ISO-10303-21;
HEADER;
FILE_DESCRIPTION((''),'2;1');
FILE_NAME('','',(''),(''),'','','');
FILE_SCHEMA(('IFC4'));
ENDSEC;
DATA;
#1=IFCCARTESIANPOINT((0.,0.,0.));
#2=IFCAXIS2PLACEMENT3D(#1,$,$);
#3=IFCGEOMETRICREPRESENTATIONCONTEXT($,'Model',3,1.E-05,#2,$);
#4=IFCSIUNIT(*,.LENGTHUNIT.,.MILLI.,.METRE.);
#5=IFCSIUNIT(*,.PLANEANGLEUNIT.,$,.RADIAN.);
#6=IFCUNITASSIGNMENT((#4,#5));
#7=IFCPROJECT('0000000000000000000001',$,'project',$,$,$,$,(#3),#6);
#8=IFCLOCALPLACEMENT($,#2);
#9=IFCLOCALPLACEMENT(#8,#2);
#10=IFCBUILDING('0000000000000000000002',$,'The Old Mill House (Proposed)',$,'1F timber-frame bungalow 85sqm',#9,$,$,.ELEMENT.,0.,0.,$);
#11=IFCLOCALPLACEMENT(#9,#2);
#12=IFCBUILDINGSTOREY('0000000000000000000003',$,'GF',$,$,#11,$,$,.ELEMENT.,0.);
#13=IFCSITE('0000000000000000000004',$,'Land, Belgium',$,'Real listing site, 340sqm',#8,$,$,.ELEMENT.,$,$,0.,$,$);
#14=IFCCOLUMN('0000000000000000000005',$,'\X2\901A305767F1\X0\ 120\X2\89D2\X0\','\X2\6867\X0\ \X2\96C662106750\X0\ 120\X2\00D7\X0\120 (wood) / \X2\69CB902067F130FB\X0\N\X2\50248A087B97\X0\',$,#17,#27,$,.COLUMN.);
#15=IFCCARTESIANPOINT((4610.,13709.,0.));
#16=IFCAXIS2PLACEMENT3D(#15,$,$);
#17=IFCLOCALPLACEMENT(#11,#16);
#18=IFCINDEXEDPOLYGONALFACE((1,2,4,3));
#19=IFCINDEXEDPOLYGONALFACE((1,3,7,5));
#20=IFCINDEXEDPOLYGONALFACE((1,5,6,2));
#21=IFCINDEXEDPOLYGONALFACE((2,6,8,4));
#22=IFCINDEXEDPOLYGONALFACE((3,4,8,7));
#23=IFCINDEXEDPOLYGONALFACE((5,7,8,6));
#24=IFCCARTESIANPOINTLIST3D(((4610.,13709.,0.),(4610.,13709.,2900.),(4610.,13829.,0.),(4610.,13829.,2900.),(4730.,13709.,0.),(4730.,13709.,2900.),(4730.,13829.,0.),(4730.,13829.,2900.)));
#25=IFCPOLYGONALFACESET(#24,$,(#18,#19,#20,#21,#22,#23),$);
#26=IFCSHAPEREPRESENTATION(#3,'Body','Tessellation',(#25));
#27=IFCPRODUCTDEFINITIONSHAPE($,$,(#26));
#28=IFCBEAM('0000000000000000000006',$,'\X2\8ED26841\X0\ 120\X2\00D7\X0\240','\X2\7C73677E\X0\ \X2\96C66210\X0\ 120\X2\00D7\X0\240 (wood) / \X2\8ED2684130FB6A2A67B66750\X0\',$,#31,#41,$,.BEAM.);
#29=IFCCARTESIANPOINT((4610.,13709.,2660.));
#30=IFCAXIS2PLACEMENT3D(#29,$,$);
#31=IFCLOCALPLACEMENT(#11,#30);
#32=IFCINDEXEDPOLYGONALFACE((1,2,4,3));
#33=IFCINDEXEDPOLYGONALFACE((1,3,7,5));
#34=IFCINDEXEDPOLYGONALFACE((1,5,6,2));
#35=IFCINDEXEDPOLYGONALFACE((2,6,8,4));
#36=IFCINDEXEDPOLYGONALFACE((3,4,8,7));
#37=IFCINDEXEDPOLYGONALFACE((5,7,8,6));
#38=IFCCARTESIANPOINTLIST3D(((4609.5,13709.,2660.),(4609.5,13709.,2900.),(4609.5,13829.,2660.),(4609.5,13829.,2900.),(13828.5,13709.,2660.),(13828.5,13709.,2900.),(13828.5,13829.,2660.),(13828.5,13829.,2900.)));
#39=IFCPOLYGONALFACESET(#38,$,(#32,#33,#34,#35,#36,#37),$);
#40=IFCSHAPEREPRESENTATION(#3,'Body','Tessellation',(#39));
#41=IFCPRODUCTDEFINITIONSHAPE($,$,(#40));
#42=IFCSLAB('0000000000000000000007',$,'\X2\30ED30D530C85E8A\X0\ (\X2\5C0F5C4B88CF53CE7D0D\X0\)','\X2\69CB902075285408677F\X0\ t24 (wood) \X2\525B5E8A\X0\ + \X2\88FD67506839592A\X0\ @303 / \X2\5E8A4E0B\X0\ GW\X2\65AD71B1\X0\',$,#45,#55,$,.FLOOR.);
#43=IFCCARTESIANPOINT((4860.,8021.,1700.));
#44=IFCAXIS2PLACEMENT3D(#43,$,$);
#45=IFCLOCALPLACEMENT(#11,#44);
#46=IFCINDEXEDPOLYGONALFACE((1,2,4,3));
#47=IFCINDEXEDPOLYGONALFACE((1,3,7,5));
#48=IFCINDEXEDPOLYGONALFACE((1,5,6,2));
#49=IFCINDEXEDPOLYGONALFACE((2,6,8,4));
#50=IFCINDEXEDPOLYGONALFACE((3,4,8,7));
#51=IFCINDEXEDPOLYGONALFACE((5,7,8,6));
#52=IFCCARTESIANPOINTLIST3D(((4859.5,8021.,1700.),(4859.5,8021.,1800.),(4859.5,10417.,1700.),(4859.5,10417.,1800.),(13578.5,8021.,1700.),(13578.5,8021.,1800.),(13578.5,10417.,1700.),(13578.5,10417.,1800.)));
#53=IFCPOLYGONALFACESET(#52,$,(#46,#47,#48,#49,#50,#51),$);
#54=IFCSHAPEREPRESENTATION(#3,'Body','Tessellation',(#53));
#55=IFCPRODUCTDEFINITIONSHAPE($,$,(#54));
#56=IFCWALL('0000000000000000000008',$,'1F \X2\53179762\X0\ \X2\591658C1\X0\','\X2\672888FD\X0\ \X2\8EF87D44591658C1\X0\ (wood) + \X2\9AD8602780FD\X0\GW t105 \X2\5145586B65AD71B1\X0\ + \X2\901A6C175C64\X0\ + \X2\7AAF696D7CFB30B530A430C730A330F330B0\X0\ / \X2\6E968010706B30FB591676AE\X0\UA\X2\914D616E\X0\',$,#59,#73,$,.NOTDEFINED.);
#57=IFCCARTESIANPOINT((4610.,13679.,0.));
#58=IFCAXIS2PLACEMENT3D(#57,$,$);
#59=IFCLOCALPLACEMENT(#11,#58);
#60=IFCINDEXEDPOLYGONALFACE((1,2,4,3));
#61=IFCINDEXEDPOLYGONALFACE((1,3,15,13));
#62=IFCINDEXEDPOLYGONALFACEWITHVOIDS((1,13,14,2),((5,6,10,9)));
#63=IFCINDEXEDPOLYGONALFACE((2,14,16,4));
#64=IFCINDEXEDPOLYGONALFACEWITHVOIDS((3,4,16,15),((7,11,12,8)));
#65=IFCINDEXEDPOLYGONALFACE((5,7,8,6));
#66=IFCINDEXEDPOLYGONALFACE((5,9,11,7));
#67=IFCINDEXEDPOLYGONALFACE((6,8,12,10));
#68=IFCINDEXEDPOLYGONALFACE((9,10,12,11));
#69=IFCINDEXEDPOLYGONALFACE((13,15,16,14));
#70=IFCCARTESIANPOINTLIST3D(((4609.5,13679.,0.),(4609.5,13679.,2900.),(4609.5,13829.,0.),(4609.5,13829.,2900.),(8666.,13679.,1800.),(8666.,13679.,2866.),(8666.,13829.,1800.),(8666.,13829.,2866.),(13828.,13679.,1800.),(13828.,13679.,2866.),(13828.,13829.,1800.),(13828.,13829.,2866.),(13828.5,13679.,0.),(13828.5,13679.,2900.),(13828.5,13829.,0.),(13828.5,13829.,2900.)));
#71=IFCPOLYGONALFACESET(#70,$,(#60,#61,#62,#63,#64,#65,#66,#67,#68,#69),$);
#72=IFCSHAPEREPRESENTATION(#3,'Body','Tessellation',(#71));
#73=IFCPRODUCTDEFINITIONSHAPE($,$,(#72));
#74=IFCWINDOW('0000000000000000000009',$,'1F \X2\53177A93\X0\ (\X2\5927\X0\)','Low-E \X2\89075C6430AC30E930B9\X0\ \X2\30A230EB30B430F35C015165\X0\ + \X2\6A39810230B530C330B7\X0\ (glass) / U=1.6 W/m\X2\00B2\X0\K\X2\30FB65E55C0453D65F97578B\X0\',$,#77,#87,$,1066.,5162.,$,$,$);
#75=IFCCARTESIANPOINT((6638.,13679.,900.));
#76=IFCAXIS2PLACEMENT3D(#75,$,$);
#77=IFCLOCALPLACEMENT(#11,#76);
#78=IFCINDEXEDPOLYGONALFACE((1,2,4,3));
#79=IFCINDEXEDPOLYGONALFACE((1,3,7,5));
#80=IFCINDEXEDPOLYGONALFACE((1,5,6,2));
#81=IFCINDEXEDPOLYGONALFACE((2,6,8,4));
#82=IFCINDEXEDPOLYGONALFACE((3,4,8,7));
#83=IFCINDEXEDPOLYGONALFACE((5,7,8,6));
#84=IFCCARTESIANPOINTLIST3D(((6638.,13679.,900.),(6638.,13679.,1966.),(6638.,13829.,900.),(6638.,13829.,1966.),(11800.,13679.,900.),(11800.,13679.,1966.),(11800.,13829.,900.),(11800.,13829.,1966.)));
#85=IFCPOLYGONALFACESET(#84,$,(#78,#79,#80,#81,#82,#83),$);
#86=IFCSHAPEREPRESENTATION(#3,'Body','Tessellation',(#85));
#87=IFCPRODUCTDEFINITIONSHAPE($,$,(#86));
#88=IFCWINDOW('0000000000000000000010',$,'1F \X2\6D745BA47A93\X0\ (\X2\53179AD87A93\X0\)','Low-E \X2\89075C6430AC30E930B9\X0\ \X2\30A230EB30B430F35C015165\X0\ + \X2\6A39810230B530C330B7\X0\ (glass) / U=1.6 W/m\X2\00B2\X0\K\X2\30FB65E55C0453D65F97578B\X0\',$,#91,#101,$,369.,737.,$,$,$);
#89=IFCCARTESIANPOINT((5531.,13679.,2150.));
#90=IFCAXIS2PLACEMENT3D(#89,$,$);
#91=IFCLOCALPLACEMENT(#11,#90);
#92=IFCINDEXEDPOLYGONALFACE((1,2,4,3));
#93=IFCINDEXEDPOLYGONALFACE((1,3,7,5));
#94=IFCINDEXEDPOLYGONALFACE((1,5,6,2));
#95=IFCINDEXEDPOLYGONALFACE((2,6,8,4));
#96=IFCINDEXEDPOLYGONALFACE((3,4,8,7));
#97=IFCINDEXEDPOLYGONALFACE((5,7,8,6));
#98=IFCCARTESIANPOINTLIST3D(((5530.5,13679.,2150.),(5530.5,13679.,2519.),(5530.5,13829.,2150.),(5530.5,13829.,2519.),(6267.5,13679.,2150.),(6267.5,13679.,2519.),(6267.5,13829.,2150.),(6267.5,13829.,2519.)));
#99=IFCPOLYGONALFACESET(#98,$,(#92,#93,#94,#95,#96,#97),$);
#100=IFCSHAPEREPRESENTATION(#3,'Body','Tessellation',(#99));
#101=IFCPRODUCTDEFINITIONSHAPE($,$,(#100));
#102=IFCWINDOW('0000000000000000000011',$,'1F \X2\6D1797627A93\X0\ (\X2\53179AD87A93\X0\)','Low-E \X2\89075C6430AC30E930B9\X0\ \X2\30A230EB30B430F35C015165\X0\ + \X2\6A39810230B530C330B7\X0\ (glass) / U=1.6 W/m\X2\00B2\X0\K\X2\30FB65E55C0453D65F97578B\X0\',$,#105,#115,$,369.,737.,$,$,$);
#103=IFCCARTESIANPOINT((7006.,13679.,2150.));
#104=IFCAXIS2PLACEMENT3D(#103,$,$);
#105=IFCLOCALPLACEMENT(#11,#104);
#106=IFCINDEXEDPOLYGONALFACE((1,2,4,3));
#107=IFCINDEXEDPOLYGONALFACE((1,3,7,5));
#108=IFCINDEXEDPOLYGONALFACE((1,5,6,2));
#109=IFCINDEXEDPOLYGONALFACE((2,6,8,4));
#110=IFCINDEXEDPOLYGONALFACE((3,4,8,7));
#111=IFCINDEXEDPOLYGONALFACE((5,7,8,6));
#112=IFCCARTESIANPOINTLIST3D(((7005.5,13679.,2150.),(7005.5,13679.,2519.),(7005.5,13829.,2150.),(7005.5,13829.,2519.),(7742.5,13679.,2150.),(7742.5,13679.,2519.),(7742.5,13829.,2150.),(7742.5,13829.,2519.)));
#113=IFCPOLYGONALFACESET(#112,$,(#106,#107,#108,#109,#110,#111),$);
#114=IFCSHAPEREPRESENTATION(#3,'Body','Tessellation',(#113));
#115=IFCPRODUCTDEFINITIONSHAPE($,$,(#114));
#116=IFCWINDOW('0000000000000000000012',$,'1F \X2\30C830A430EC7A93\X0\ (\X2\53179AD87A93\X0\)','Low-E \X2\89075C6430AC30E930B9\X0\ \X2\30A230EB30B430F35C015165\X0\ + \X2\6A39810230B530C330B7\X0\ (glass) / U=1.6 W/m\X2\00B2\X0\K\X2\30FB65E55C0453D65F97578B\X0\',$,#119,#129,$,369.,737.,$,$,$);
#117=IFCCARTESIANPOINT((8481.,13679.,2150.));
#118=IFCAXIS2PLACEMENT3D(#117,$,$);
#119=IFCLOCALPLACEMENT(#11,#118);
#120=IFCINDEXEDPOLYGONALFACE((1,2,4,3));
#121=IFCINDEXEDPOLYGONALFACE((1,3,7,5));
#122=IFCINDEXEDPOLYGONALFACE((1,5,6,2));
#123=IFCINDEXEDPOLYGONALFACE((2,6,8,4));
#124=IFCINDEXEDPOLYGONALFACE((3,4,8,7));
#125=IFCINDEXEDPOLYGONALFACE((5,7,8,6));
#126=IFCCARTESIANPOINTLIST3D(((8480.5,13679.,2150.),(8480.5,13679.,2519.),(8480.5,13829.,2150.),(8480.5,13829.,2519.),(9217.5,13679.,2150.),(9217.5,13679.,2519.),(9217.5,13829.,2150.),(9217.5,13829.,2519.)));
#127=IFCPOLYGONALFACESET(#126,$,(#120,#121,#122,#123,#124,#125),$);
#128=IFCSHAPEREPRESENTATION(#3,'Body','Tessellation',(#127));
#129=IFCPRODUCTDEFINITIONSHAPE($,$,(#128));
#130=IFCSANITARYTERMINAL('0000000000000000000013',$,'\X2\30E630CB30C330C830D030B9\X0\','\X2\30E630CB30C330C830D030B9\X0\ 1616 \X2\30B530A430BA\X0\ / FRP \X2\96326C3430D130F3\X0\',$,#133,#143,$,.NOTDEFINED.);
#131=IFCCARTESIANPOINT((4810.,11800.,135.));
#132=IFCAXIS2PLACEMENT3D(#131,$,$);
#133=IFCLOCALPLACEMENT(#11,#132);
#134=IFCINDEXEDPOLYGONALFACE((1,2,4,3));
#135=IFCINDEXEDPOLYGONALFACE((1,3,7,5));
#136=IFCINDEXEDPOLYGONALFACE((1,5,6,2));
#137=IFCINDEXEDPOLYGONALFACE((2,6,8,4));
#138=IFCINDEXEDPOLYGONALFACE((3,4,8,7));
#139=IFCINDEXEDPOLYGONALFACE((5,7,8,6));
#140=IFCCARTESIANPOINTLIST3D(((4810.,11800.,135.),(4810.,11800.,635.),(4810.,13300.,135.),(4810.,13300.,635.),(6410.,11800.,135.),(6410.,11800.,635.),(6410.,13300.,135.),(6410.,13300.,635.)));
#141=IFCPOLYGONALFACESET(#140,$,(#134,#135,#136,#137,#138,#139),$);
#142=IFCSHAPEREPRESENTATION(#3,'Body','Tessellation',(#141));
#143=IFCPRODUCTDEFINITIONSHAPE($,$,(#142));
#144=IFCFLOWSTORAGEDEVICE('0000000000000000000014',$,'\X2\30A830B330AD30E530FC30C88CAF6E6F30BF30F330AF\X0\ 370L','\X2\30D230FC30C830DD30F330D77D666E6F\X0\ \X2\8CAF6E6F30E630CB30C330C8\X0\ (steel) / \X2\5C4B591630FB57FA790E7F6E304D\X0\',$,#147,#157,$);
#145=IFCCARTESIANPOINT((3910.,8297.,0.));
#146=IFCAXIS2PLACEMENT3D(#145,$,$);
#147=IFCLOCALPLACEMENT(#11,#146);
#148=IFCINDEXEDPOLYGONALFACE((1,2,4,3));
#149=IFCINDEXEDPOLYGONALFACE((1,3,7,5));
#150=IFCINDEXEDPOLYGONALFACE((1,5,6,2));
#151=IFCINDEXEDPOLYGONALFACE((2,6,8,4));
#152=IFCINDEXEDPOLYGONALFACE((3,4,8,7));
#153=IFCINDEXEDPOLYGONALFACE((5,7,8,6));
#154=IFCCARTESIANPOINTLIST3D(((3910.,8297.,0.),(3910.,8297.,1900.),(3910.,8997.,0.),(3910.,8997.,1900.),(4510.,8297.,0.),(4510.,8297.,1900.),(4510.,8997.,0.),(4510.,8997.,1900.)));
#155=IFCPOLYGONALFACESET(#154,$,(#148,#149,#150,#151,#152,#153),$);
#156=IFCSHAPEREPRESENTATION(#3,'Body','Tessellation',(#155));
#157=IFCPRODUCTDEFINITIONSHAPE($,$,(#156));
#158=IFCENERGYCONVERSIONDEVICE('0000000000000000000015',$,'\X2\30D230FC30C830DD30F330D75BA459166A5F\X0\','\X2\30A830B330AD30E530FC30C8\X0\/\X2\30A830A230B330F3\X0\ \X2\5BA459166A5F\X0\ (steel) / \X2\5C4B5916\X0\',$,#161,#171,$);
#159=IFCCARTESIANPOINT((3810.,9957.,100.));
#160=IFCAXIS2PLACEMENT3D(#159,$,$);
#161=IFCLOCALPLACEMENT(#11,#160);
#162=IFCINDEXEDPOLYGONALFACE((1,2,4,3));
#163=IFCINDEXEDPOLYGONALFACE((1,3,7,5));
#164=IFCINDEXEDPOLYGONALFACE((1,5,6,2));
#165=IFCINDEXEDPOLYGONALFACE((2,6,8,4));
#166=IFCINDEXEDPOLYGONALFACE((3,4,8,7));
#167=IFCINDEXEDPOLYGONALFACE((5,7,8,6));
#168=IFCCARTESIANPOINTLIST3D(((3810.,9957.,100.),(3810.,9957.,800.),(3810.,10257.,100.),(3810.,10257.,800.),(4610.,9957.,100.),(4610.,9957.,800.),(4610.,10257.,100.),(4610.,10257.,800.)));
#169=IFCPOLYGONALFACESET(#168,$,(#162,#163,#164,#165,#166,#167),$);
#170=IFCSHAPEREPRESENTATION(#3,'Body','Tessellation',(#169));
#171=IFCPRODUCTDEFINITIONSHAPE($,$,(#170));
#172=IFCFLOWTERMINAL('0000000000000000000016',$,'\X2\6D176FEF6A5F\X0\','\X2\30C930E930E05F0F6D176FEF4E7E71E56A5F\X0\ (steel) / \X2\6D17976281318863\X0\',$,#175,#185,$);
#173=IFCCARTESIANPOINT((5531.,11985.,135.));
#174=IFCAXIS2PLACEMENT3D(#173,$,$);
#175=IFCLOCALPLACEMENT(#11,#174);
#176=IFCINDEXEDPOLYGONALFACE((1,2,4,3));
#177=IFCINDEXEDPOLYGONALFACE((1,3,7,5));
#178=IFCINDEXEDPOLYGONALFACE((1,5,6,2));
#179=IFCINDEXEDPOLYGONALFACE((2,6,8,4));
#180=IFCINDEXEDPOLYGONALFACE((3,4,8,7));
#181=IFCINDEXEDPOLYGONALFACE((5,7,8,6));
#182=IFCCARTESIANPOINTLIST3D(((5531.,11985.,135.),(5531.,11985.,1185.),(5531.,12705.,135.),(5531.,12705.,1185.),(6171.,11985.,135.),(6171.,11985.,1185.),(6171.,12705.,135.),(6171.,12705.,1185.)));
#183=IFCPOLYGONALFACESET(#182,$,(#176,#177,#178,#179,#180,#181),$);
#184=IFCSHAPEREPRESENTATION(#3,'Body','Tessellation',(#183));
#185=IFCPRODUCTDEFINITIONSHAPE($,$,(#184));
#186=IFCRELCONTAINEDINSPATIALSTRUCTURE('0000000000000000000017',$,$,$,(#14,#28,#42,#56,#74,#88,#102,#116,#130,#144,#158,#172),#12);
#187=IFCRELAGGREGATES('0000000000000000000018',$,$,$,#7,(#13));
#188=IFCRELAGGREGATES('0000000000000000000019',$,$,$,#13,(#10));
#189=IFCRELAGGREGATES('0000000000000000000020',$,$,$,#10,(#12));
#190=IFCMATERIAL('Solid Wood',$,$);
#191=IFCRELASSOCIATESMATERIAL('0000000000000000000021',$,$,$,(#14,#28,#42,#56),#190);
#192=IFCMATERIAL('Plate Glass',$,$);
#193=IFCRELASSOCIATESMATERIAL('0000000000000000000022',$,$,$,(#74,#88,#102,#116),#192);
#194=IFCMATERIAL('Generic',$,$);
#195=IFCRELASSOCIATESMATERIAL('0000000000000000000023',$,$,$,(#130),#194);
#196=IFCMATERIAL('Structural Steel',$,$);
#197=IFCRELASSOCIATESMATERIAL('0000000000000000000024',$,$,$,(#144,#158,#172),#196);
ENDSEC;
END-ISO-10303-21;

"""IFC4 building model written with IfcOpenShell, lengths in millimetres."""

from ifc_helpers import new_model, si_unit, frame, frame_2d, origin, place, context, project, spatial, rectangle, extrude, material, element, fill, save


model = new_model("IFC4")

# Units and contexts
model_context = context("Model", 3, precision=1e-05, world=origin())
ifc_project = project(units=[si_unit("LENGTHUNIT", "METRE", prefix="MILLI"), si_unit("PLANEANGLEUNIT", "RADIAN")], contexts=[model_context])

# Site, building, storey
site_placement = place(None, origin())
site = spatial("IfcSite", under=ifc_project, at=site_placement, Name="Land, Belgium", ObjectType="Real listing site, 340sqm", CompositionType="ELEMENT", RefElevation=0.0)
building_placement = place(site_placement, origin())
building = spatial("IfcBuilding", under=site, at=building_placement, Name="The Old Mill House (Proposed)", ObjectType="1F timber-frame bungalow 85sqm", CompositionType="ELEMENT", ElevationOfRefHeight=0.0, ElevationOfTerrain=0.0)
storey_placement = place(building_placement, origin())
storey = spatial("IfcBuildingStorey", under=building, at=storey_placement, Name="GF", CompositionType="ELEMENT", Elevation=0.0)

# Column
ifc_material_1 = material(Name="Solid Wood")
column_1_placement = place(storey_placement, frame((4610.0, 13709.0, 0.0)))
element("IfcColumn", 1, at=column_1_placement, inside=storey, material=ifc_material_1, Name="通し柱 120角", Description="桧 集成材 120×120 (wood) / 構造柱・N値計算", PredefinedType="COLUMN", context=model_context, shape_type="SweptSolid", body=[
    extrude(rectangle(XDim=120.0, YDim=120.0, at=frame_2d((60.0, 60.0))), frame((4610.0, 13709.0, 0.0)), (0.0, 0.0, 1.0), 2900.0),
])

# Beam
beam_1_placement = place(storey_placement, frame((4610.0, 13709.0, 2660.0)))
element("IfcBeam", 2, at=beam_1_placement, inside=storey, material=ifc_material_1, Name="軒桁 120×240", Description="米松 集成 120×240 (wood) / 軒桁・横架材", PredefinedType="BEAM", context=model_context, shape_type="SweptSolid", body=[
    extrude(rectangle(XDim=9219.0, YDim=120.0, at=frame_2d((4609.0, 60.0))), frame((4610.0, 13709.0, 2660.0)), (0.0, 0.0, 1.0), 240.0),
])

# Slab
slab_placement = place(storey_placement, frame((4860.0, 8021.0, 1700.0)))
element("IfcSlab", 3, at=slab_placement, inside=storey, material=ifc_material_1, Name="ロフト床 (小屋裏収納)", Description="構造用合板 t24 (wood) 剛床 + 製材根太 @303 / 床下 GW断熱", PredefinedType="FLOOR", context=model_context, shape_type="SweptSolid", body=[
    extrude(rectangle(XDim=8719.0, YDim=2396.0, at=frame_2d((4359.0, 1198.0))), frame((4860.0, 8021.0, 1700.0)), (0.0, 0.0, 1.0), 100.0),
])

# Wall, openings, windows
wall_1_placement = place(storey_placement, frame((4610.0, 13679.0, 0.0)))
wall_1 = element("IfcWall", 4, at=wall_1_placement, inside=storey, material=ifc_material_1, Name="1F 北面 外壁", Description="木製 軸組外壁 (wood) + 高性能GW t105 充填断熱 + 通気層 + 窯業系サイディング / 準耐火・外皮UA配慮", PredefinedType="NOTDEFINED", context=model_context, shape_type="SweptSolid", body=[
    extrude(rectangle(XDim=9219.0, YDim=150.0, at=frame_2d((4609.0, 75.0))), frame((4610.0, 13679.0, 0.0)), (0.0, 0.0, 1.0), 2900.0),
])
opening_1_placement = place(storey_placement, frame((6638.0, 13679.0, 900.0)))
opening_1 = element("IfcOpeningElement", 5, at=opening_1_placement, cuts=wall_1, PredefinedType="NOTDEFINED", context=model_context, shape_type="SweptSolid", body=[
    extrude(rectangle(XDim=5162.0, YDim=150.0, at=frame_2d((2581.0, 75.0))), frame((6638.0, 13679.0, 900.0)), (0.0, 0.0, 1.0), 1066.0),
])
opening_2_placement = place(storey_placement, frame((5531.0, 13679.0, 2150.0)))
opening_2 = element("IfcOpeningElement", 6, at=opening_2_placement, cuts=wall_1, PredefinedType="NOTDEFINED", context=model_context, shape_type="SweptSolid", body=[
    extrude(rectangle(XDim=737.0, YDim=150.0, at=frame_2d((368.0, 75.0))), frame((5531.0, 13679.0, 2150.0)), (0.0, 0.0, 1.0), 369.0),
])
opening_3_placement = place(storey_placement, frame((7006.0, 13679.0, 2150.0)))
opening_3 = element("IfcOpeningElement", 7, at=opening_3_placement, cuts=wall_1, PredefinedType="NOTDEFINED", context=model_context, shape_type="SweptSolid", body=[
    extrude(rectangle(XDim=737.0, YDim=150.0, at=frame_2d((368.0, 75.0))), frame((7006.0, 13679.0, 2150.0)), (0.0, 0.0, 1.0), 369.0),
])
opening_4_placement = place(storey_placement, frame((8481.0, 13679.0, 2150.0)))
opening_4 = element("IfcOpeningElement", 8, at=opening_4_placement, cuts=wall_1, PredefinedType="NOTDEFINED", context=model_context, shape_type="SweptSolid", body=[
    extrude(rectangle(XDim=737.0, YDim=150.0, at=frame_2d((368.0, 75.0))), frame((8481.0, 13679.0, 2150.0)), (0.0, 0.0, 1.0), 369.0),
])
ifc_material_2 = material(Name="Plate Glass")
window_1_placement = place(storey_placement, frame((6638.0, 13679.0, 900.0)))
window_1 = element("IfcWindow", 9, at=window_1_placement, inside=storey, material=ifc_material_2, Name="1F 北窓 (大)", Description="Low-E 複層ガラス アルゴン封入 + 樹脂サッシ (glass) / U=1.6 W/m²K・日射取得型", OverallHeight=1066.0, OverallWidth=5162.0, context=model_context, shape_type="SweptSolid", body=[
    extrude(rectangle(XDim=5162.0, YDim=150.0, at=frame_2d((2581.0, 75.0))), frame((6638.0, 13679.0, 900.0)), (0.0, 0.0, 1.0), 1066.0),
])
fill(opening_1, window_1)
window_2_placement = place(storey_placement, frame((5531.0, 13679.0, 2150.0)))
window_2 = element("IfcWindow", 10, at=window_2_placement, inside=storey, material=ifc_material_2, Name="1F 浴室窓 (北高窓)", Description="Low-E 複層ガラス アルゴン封入 + 樹脂サッシ (glass) / U=1.6 W/m²K・日射取得型", OverallHeight=369.0, OverallWidth=737.0, context=model_context, shape_type="SweptSolid", body=[
    extrude(rectangle(XDim=737.0, YDim=150.0, at=frame_2d((368.0, 75.0))), frame((5531.0, 13679.0, 2150.0)), (0.0, 0.0, 1.0), 369.0),
])
fill(opening_2, window_2)
window_3_placement = place(storey_placement, frame((7006.0, 13679.0, 2150.0)))
window_3 = element("IfcWindow", 11, at=window_3_placement, inside=storey, material=ifc_material_2, Name="1F 洗面窓 (北高窓)", Description="Low-E 複層ガラス アルゴン封入 + 樹脂サッシ (glass) / U=1.6 W/m²K・日射取得型", OverallHeight=369.0, OverallWidth=737.0, context=model_context, shape_type="SweptSolid", body=[
    extrude(rectangle(XDim=737.0, YDim=150.0, at=frame_2d((368.0, 75.0))), frame((7006.0, 13679.0, 2150.0)), (0.0, 0.0, 1.0), 369.0),
])
fill(opening_3, window_3)
window_4_placement = place(storey_placement, frame((8481.0, 13679.0, 2150.0)))
window_4 = element("IfcWindow", 12, at=window_4_placement, inside=storey, material=ifc_material_2, Name="1F トイレ窓 (北高窓)", Description="Low-E 複層ガラス アルゴン封入 + 樹脂サッシ (glass) / U=1.6 W/m²K・日射取得型", OverallHeight=369.0, OverallWidth=737.0, context=model_context, shape_type="SweptSolid", body=[
    extrude(rectangle(XDim=737.0, YDim=150.0, at=frame_2d((368.0, 75.0))), frame((8481.0, 13679.0, 2150.0)), (0.0, 0.0, 1.0), 369.0),
])
fill(opening_4, window_4)

# Shared definitions
ifc_material_3 = material(Name="Structural Steel")

# Sanitary terminal
ifc_material_4 = material(Name="Generic")
sanitary_terminal_placement = place(storey_placement, frame((4810.0, 11800.0, 135.0)))
element("IfcSanitaryTerminal", 13, at=sanitary_terminal_placement, inside=storey, material=ifc_material_4, Name="ユニットバス", Description="ユニットバス 1616 サイズ / FRP 防水パン", PredefinedType="NOTDEFINED", context=model_context, shape_type="SweptSolid", body=[
    extrude(rectangle(XDim=1600.0, YDim=1500.0, at=frame_2d((800.0, 750.0))), frame((4810.0, 11800.0, 135.0)), (0.0, 0.0, 1.0), 500.0),
])

# Flow storage device
flow_storage_device_placement = place(storey_placement, frame((3910.0, 8297.0, 0.0)))
element("IfcFlowStorageDevice", 14, at=flow_storage_device_placement, inside=storey, material=ifc_material_3, Name="エコキュート貯湯タンク 370L", Description="ヒートポンプ給湯 貯湯ユニット (steel) / 屋外・基礎置き", context=model_context, shape_type="SweptSolid", body=[
    extrude(rectangle(XDim=600.0, YDim=700.0, at=frame_2d((300.0, 350.0))), frame((3910.0, 8297.0, 0.0)), (0.0, 0.0, 1.0), 1900.0),
])

# Energy conversion device
energy_conversion_device_placement = place(storey_placement, frame((3810.0, 9957.0, 100.0)))
element("IfcEnergyConversionDevice", 15, at=energy_conversion_device_placement, inside=storey, material=ifc_material_3, Name="ヒートポンプ室外機", Description="エコキュート/エアコン 室外機 (steel) / 屋外", context=model_context, shape_type="SweptSolid", body=[
    extrude(rectangle(XDim=800.0, YDim=300.0, at=frame_2d((400.0, 150.0))), frame((3810.0, 9957.0, 100.0)), (0.0, 0.0, 1.0), 700.0),
])

# Flow terminal
flow_terminal_placement = place(storey_placement, frame((5531.0, 11985.0, 135.0)))
element("IfcFlowTerminal", 16, at=flow_terminal_placement, inside=storey, material=ifc_material_3, Name="洗濯機", Description="ドラム式洗濯乾燥機 (steel) / 洗面脱衣", context=model_context, shape_type="SweptSolid", body=[
    extrude(rectangle(XDim=640.0, YDim=720.0, at=frame_2d((320.0, 360.0))), frame((5531.0, 11985.0, 135.0)), (0.0, 0.0, 1.0), 1050.0),
])

save(model, "model.ifc")
